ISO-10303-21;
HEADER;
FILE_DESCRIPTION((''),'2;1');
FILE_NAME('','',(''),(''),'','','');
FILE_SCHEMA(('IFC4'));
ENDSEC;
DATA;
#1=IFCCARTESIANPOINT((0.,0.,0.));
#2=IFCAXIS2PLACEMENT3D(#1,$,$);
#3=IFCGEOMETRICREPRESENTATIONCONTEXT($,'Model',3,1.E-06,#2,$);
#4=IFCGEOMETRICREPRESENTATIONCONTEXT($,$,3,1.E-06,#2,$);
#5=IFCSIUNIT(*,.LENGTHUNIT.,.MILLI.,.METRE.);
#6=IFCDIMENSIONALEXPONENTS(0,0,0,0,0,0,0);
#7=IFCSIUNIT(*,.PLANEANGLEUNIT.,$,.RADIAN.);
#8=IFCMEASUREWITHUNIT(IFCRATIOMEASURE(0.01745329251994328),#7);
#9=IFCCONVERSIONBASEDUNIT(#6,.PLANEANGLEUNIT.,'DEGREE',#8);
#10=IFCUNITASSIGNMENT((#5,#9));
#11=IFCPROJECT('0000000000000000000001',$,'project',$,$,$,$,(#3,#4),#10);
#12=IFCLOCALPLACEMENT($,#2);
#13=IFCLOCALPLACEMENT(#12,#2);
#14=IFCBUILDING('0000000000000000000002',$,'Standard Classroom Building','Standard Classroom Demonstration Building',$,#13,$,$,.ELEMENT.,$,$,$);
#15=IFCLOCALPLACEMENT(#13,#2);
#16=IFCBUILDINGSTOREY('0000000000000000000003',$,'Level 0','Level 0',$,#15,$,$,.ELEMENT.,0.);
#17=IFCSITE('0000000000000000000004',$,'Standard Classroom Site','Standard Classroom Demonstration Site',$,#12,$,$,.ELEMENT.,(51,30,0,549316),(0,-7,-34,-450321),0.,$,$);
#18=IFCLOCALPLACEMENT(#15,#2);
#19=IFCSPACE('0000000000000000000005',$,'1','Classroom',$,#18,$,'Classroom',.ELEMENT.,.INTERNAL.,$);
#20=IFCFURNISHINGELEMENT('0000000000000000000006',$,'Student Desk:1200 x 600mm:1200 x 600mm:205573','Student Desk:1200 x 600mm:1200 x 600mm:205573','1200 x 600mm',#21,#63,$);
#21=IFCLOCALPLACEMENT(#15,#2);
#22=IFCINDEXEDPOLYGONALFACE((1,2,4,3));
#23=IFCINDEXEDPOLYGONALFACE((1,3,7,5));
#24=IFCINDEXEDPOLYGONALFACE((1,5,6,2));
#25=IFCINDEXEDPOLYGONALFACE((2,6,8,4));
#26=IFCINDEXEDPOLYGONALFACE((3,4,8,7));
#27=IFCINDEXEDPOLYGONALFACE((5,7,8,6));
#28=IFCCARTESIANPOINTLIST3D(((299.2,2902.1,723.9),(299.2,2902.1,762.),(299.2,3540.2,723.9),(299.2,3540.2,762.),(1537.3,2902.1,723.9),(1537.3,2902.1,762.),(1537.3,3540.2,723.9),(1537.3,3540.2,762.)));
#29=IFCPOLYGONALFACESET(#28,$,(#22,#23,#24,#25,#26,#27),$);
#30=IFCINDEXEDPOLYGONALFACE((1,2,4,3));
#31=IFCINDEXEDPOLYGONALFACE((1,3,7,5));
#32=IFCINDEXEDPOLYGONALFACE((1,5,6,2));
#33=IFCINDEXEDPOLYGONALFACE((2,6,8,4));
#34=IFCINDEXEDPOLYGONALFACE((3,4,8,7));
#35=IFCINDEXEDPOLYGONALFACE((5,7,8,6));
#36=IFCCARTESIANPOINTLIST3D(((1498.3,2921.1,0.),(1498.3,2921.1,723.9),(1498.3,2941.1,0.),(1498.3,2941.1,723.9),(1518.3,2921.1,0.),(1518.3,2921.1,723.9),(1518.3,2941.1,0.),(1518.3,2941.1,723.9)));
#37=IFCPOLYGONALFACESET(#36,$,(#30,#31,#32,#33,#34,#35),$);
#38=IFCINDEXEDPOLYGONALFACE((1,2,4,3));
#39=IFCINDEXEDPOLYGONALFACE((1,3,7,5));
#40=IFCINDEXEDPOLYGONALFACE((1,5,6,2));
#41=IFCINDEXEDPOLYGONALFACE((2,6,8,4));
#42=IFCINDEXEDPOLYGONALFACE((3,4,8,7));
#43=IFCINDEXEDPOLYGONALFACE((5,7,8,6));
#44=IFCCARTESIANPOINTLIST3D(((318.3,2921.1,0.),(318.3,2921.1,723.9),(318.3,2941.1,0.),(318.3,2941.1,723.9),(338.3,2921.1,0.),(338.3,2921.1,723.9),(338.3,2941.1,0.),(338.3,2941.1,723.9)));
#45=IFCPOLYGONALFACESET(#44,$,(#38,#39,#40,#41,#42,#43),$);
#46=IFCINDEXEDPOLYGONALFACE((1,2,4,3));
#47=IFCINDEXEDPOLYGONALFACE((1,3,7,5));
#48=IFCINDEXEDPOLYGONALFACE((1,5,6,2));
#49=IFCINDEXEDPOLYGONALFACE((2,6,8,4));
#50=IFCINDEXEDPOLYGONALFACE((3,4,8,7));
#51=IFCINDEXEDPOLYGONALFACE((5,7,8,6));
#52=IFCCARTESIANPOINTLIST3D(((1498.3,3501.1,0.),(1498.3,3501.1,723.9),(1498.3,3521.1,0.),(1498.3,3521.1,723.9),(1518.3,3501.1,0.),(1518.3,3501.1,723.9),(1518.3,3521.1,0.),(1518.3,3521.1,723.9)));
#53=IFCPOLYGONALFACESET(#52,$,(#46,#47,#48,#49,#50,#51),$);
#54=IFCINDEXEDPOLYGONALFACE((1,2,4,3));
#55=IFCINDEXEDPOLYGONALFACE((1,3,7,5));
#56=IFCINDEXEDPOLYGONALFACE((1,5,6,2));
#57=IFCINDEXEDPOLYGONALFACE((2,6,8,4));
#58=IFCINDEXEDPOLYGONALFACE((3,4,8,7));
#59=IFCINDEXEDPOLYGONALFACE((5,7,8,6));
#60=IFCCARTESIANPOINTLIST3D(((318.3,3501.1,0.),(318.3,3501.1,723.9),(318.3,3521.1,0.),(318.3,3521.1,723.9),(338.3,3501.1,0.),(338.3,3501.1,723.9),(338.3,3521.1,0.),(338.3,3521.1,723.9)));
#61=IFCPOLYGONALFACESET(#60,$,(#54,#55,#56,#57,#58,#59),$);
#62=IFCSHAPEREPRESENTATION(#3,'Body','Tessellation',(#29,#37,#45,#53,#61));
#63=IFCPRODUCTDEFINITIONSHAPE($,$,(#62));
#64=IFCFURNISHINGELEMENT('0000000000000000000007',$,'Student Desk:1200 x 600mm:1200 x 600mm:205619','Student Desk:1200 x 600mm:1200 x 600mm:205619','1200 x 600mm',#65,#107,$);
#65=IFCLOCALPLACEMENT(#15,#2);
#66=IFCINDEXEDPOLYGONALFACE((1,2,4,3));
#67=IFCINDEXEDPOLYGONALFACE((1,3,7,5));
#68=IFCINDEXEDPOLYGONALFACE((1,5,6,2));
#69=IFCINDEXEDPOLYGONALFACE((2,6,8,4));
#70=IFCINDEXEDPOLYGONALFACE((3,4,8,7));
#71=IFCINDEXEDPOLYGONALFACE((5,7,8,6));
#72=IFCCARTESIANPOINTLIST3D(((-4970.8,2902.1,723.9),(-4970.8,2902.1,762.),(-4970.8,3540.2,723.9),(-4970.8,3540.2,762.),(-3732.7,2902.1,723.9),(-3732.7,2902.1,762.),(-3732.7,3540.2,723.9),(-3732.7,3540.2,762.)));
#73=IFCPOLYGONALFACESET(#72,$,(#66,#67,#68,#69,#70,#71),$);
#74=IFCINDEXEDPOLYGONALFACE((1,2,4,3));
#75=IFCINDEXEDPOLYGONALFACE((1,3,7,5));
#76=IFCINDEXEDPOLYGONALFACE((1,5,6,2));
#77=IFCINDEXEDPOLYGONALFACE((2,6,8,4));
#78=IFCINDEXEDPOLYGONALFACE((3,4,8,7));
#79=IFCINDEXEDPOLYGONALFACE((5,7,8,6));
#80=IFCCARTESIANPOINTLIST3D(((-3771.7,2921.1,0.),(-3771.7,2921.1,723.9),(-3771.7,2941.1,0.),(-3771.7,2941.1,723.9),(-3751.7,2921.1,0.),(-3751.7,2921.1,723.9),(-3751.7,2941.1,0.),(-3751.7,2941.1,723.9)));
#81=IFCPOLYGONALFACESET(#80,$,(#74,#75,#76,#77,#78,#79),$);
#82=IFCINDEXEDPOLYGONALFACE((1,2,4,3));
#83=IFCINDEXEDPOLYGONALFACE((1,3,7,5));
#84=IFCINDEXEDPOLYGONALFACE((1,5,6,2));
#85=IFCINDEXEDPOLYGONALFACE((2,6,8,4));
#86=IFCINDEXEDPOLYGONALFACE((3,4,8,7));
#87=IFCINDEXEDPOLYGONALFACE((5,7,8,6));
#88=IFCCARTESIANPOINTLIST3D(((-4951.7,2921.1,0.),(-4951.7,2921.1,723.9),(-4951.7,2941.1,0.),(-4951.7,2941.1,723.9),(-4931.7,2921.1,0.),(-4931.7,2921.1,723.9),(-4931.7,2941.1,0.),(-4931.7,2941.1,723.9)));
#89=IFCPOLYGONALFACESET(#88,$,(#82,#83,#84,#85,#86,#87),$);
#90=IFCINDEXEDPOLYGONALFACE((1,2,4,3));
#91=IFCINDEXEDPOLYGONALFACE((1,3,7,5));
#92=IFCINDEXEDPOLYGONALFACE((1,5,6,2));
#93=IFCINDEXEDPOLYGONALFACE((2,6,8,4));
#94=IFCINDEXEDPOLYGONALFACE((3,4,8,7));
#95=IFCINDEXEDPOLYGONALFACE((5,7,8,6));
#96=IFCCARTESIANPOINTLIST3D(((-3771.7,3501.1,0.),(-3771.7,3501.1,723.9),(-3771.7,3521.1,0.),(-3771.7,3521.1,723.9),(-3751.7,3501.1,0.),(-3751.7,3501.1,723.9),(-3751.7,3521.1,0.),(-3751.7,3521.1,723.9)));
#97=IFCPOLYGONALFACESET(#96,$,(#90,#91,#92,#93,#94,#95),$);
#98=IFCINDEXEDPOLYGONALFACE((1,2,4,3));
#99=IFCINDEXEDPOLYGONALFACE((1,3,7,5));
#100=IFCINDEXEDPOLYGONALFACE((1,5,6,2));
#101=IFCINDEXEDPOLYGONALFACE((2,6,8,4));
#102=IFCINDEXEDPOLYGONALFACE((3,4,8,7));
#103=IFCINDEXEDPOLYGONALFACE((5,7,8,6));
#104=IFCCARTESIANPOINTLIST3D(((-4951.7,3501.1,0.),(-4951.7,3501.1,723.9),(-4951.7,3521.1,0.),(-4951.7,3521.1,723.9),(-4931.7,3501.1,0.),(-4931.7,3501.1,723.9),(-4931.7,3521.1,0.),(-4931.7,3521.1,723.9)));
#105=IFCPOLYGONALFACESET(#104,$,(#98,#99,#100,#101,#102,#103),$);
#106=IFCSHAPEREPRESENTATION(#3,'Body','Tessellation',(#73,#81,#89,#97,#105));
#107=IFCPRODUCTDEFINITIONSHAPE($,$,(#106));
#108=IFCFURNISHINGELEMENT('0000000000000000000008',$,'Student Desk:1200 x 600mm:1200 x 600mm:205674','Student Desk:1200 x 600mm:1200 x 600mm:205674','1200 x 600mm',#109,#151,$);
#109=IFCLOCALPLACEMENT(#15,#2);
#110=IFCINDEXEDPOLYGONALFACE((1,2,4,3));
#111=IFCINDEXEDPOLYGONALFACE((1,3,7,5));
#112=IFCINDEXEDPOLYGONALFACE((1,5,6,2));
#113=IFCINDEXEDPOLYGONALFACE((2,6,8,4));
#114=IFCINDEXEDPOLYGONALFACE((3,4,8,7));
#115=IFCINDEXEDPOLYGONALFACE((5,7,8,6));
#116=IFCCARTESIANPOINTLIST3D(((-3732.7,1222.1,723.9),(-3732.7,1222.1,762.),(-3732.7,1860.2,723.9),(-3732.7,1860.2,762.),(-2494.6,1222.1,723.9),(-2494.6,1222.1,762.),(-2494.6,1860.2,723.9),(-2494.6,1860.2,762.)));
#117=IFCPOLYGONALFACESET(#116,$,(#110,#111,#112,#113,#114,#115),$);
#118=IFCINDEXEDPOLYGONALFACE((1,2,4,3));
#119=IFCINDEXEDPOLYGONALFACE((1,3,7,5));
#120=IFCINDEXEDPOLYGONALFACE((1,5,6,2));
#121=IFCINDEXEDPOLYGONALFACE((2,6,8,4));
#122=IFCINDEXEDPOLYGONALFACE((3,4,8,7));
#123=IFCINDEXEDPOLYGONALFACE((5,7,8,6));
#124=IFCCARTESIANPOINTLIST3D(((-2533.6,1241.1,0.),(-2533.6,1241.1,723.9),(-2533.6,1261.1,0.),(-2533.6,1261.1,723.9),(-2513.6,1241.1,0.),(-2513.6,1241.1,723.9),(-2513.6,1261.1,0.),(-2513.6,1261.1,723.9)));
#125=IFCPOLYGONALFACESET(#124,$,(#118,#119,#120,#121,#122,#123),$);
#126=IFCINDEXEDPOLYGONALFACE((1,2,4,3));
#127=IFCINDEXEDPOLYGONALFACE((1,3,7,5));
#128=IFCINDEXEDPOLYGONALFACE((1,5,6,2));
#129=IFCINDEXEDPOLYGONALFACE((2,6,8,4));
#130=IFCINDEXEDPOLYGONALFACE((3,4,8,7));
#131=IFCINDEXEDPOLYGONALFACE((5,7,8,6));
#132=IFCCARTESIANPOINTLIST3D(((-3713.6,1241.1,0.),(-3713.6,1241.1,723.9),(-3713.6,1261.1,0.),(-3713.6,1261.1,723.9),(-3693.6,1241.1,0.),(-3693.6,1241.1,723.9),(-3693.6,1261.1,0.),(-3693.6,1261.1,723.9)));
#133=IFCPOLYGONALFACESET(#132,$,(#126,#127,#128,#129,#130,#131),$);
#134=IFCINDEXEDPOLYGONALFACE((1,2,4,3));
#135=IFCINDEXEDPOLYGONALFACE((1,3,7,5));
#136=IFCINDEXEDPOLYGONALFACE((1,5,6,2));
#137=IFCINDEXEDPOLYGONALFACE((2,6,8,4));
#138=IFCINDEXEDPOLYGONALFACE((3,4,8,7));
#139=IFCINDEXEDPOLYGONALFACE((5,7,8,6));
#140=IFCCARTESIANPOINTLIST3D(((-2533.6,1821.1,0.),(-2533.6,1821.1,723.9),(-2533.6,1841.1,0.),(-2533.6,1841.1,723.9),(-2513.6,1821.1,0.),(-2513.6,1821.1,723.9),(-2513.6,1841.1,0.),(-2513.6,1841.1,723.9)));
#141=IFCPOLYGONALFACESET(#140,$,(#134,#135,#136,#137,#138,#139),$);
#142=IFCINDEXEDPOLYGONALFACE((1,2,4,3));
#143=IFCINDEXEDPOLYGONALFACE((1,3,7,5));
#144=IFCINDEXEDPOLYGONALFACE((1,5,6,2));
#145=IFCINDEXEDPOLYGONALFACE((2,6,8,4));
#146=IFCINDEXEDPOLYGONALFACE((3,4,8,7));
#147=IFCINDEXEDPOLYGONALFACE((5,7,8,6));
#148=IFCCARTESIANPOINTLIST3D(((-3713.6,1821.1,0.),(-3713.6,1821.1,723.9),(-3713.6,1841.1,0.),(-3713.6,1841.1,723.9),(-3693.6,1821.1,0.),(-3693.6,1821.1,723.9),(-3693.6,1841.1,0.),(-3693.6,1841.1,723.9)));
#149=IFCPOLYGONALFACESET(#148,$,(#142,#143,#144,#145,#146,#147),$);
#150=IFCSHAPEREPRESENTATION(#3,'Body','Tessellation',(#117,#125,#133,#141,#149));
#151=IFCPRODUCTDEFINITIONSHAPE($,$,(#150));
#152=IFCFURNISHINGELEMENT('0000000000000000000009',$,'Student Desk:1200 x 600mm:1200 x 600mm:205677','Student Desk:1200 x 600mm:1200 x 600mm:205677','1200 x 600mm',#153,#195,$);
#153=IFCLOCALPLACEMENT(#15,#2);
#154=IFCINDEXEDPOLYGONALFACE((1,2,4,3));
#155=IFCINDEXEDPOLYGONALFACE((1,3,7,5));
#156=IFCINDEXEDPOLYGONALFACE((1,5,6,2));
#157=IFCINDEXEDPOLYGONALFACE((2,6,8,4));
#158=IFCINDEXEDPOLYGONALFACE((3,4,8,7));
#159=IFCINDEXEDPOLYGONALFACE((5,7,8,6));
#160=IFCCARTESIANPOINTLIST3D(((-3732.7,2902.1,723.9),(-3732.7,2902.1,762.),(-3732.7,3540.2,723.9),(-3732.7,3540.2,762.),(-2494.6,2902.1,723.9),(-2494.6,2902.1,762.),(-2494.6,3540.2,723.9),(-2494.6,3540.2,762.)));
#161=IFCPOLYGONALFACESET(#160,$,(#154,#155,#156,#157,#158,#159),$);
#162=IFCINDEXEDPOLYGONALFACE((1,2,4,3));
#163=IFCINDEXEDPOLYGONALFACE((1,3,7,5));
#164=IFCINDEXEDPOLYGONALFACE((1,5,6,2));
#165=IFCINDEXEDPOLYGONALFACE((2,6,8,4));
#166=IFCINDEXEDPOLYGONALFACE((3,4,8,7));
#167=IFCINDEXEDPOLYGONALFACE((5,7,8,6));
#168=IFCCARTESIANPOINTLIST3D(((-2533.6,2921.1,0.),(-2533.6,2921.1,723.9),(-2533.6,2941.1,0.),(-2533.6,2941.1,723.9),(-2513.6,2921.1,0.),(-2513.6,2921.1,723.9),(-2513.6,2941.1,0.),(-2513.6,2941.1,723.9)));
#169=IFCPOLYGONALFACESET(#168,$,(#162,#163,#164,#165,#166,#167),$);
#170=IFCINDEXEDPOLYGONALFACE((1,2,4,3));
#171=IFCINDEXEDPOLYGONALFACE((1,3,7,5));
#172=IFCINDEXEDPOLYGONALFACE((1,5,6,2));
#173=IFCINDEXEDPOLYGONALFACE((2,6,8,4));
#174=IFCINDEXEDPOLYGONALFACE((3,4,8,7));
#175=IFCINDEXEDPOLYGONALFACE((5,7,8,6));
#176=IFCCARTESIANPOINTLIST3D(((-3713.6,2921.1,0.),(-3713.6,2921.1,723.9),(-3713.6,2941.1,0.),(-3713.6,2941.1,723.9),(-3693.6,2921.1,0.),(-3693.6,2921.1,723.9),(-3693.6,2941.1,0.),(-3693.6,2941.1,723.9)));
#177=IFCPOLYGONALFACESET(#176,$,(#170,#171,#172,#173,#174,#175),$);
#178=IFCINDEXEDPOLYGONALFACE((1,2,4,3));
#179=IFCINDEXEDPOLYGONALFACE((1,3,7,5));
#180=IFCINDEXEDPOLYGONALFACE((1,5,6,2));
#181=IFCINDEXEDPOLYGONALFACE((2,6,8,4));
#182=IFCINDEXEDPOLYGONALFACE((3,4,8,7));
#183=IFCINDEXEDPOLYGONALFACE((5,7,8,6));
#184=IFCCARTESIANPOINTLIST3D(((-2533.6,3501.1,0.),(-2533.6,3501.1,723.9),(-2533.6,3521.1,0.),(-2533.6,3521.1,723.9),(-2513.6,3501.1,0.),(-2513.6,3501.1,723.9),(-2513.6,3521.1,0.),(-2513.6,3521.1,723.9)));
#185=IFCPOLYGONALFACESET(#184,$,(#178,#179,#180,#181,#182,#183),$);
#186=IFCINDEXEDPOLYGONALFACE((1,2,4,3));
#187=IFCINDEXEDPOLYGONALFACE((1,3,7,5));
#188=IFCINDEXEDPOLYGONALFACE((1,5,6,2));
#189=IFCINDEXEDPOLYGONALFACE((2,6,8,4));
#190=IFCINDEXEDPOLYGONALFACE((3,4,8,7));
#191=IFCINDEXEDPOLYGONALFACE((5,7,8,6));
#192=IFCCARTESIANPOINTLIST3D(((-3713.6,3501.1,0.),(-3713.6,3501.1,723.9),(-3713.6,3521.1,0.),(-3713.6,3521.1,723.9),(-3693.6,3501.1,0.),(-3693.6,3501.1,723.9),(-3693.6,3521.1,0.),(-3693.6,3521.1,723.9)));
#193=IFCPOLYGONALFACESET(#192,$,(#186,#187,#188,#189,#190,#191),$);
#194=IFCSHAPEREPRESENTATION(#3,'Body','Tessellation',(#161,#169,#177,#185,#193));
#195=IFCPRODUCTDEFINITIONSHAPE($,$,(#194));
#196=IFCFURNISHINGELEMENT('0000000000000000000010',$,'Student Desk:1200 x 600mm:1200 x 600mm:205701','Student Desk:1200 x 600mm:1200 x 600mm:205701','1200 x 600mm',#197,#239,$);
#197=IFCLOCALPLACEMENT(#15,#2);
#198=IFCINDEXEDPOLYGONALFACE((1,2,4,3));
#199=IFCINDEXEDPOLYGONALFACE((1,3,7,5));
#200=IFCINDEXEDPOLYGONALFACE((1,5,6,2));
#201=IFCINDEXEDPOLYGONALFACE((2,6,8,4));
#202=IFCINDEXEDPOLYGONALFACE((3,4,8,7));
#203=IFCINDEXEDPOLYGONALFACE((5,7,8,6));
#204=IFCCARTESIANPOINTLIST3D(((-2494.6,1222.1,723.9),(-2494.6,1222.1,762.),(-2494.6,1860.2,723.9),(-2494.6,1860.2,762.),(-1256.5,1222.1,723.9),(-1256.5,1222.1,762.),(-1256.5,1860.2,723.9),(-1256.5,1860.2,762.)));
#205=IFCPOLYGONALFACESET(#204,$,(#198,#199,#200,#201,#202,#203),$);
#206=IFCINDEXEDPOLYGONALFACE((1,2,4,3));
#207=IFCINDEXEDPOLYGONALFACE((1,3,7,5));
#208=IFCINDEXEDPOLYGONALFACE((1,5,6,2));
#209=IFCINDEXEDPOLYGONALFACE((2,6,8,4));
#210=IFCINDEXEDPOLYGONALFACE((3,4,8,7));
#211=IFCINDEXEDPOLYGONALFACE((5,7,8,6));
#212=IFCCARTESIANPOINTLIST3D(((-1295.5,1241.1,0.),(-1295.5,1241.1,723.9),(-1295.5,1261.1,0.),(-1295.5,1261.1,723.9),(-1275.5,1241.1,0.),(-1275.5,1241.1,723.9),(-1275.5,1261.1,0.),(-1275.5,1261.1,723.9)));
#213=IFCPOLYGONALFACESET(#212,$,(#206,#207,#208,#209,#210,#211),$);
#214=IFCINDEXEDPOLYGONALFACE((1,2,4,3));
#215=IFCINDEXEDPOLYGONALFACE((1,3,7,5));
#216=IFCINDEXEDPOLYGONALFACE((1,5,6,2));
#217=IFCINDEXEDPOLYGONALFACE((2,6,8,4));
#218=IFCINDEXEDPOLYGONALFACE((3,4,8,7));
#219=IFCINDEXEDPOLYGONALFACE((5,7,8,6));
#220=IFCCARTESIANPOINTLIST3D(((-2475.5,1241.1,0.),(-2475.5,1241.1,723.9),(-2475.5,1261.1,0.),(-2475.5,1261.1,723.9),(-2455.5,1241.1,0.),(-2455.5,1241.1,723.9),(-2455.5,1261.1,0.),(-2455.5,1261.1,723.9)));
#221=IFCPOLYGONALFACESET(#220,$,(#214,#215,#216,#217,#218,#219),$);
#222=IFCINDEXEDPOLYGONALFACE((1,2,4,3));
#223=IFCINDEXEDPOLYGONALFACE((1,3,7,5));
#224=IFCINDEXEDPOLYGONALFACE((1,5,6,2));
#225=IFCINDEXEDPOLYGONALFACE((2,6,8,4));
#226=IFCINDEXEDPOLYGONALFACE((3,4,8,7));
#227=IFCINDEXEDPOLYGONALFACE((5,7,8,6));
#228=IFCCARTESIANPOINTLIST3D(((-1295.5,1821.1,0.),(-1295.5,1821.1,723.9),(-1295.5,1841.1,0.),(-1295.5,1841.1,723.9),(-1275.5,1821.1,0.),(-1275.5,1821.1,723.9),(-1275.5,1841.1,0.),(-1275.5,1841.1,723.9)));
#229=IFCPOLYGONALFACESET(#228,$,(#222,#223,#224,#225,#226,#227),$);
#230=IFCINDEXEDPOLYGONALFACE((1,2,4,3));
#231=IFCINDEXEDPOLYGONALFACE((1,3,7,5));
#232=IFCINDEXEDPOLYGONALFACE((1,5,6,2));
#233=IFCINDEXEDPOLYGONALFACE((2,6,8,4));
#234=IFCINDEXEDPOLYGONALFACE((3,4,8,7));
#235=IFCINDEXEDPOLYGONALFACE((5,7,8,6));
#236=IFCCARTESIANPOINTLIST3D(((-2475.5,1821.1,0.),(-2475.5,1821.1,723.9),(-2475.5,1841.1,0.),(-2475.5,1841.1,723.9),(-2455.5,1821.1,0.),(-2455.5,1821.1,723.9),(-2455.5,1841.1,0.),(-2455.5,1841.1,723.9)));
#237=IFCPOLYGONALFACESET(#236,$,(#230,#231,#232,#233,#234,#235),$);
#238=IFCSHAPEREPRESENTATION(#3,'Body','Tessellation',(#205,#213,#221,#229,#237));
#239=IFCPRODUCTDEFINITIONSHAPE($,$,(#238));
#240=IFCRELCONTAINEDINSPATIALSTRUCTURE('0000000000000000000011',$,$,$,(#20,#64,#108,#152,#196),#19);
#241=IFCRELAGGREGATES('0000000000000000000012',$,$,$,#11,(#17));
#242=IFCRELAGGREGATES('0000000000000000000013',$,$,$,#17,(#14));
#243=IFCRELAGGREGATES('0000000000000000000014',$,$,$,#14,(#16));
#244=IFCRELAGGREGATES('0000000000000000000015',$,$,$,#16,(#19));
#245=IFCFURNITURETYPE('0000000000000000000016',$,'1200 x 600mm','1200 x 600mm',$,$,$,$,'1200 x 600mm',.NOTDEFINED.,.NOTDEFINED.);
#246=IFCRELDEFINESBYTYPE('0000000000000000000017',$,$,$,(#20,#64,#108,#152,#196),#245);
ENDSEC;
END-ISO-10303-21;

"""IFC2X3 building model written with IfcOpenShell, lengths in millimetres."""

from ifc_helpers import new_model, entity, si_unit, converted_unit, frame, origin, origin_2d_with_axis, place, context, project, spatial, rectangle, extrude, source, transform, mapped, type_object, type_shapes, element, save


model = new_model("IFC2X3")

# Units and contexts
model_context = context("Model", 3, precision=1e-06, world=origin())
context_of_model = context(None, 3, precision=1e-06, world=origin())
ifc_project = project(units=[si_unit("LENGTHUNIT", "METRE", prefix="MILLI"), converted_unit("PLANEANGLEUNIT", "DEGREE", entity("IfcRatioMeasure", 0.01745329251994328), si_unit("PLANEANGLEUNIT", "RADIAN"), dimensions=[0, 0, 0, 0, 0, 0, 0])], contexts=[model_context, context_of_model])

# Site, building, storey
site_placement = place(None, origin())
site = spatial("IfcSite", under=ifc_project, at=site_placement, Name="Standard Classroom Site", Description="Standard Classroom Demonstration Site", CompositionType="ELEMENT", RefLatitude=(51, 30, 0, 549316), RefLongitude=(0, -7, -34, -450321), RefElevation=0.0)
building_placement = place(site_placement, origin())
building = spatial("IfcBuilding", under=site, at=building_placement, Name="Standard Classroom Building", Description="Standard Classroom Demonstration Building", CompositionType="ELEMENT")
storey_placement = place(building_placement, origin())
storey = spatial("IfcBuildingStorey", under=building, at=storey_placement, Name="Level 0", Description="Level 0", CompositionType="ELEMENT", Elevation=0.0)

# Shared definitions
space_placement = place(storey_placement, origin())
space = spatial("IfcSpace", under=storey, at=space_placement, Name="1", Description="Classroom", LongName="Classroom", CompositionType="ELEMENT", InteriorOrExteriorSpace="INTERNAL")

# Furnishing elements
furniture_type = type_object("IfcFurnitureType", Name="1200 x 600mm", Description="1200 x 600mm", ElementType="1200 x 600mm", AssemblyPlace="NOTDEFINED")
shared_shape_1 = source(origin(), model_context, "Body", "SweptSolid", [
    extrude(rectangle(XDim=1238.1, YDim=638.1, at=origin_2d_with_axis()), frame((600.0, 300.0, 723.9), z_axis=(0.0, 0.0, 1.0), x_axis=(-1.0, 0.0, 0.0)), (0.0, 0.0, 1.0), 38.1),
    extrude(rectangle(XDim=20.0, YDim=20.0, at=origin_2d_with_axis()), frame((1190.0, 10.0, 0.0)), (0.0, 0.0, 1.0), 723.9),
    extrude(rectangle(XDim=20.0, YDim=20.0, at=origin_2d_with_axis()), frame((10.0, 10.0, 0.0), z_axis=(0.0, 0.0, 1.0), x_axis=(0.0, 1.0, 0.0)), (0.0, 0.0, 1.0), 723.9),
    extrude(rectangle(XDim=20.0, YDim=20.0, at=origin_2d_with_axis()), frame((1190.0, 590.0, 0.0), z_axis=(0.0, 0.0, 1.0), x_axis=(0.0, -1.0, 0.0)), (0.0, 0.0, 1.0), 723.9),
    extrude(rectangle(XDim=20.0, YDim=20.0, at=origin_2d_with_axis()), frame((10.0, 590.0, 0.0), z_axis=(0.0, 0.0, 1.0), x_axis=(-1.0, 0.0, 0.0)), (0.0, 0.0, 1.0), 723.9),
])
type_shapes(furniture_type, [shared_shape_1])
for number, where, name, description in (
    (1, (318.3, 2921.1, 0.0), "Student Desk:1200 x 600mm:1200 x 600mm:205573", "Student Desk:1200 x 600mm:1200 x 600mm:205573"),
    (2, (-4951.7, 2921.1, 0.0), "Student Desk:1200 x 600mm:1200 x 600mm:205619", "Student Desk:1200 x 600mm:1200 x 600mm:205619"),
    (3, (-3713.6, 1241.1, 0.0), "Student Desk:1200 x 600mm:1200 x 600mm:205674", "Student Desk:1200 x 600mm:1200 x 600mm:205674"),
    (4, (-3713.6, 2921.1, 0.0), "Student Desk:1200 x 600mm:1200 x 600mm:205677", "Student Desk:1200 x 600mm:1200 x 600mm:205677"),
    (5, (-2475.5, 1241.1, 0.0), "Student Desk:1200 x 600mm:1200 x 600mm:205701", "Student Desk:1200 x 600mm:1200 x 600mm:205701"),
):
    element("IfcFurnishingElement", number, at=place(space_placement, frame(where)), inside=space, type_object=furniture_type, Name=name, Description=description, ObjectType="1200 x 600mm", context=model_context, shape_type="MappedRepresentation", body=[
        mapped(shared_shape_1, transform((0.0, 0.0, 0.0), scale=1.0)),
    ])

save(model, "model.ifc")
